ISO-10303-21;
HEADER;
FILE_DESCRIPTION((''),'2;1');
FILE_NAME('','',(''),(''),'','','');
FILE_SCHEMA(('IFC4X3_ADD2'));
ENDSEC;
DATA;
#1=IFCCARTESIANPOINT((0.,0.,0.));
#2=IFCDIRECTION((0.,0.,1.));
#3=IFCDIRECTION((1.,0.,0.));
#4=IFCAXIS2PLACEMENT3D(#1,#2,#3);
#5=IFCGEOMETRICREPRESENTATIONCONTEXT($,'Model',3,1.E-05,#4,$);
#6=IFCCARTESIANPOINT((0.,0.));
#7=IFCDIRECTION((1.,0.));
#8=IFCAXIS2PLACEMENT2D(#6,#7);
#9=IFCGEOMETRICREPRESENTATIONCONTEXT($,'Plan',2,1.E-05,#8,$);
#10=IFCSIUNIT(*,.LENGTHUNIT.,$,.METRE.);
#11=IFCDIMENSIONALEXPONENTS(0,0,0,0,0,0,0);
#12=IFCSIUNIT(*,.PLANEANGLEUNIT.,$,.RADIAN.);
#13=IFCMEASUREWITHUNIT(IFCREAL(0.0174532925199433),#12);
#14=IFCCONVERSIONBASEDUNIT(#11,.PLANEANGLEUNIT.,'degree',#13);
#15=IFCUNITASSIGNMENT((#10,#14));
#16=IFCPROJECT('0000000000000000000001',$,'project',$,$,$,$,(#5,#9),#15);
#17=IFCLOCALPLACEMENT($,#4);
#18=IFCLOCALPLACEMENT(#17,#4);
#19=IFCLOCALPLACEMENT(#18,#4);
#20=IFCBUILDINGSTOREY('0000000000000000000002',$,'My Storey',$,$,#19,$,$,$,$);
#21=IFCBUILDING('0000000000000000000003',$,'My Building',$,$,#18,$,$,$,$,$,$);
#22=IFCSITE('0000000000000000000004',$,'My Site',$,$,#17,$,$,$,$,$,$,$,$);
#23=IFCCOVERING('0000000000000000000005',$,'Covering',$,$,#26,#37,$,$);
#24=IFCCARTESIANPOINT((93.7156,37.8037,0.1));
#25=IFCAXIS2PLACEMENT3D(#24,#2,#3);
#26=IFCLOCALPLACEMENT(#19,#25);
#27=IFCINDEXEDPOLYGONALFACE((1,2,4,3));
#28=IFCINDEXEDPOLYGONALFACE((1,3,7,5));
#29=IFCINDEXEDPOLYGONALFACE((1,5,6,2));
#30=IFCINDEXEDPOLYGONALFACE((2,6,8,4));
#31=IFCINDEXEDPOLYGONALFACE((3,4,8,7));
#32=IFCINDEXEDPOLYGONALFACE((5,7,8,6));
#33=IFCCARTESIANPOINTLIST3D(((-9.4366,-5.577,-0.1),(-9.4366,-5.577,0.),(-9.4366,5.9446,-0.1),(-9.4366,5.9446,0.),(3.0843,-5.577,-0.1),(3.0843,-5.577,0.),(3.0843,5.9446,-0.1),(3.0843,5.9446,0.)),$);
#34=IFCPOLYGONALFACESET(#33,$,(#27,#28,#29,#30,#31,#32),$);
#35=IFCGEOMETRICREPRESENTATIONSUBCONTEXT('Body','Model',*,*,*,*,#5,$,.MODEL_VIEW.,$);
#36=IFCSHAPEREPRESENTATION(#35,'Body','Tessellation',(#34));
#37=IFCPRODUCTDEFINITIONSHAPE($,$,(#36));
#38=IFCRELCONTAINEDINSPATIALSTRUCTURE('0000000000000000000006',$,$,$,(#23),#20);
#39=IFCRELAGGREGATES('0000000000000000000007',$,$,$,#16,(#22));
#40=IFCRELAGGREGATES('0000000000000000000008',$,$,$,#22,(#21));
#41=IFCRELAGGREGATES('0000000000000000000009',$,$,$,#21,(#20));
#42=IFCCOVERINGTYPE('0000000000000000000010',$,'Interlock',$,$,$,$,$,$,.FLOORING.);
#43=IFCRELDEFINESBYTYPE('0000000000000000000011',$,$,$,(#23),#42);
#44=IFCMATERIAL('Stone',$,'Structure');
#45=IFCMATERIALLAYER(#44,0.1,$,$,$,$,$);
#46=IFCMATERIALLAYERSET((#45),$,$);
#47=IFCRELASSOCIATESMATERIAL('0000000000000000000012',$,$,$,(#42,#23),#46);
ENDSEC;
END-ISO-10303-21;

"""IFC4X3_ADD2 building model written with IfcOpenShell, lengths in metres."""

from ifc_helpers import new_model, entity, si_unit, converted_unit, frame, origin_with_axes, origin_2d_with_axis, place, context, subcontext, project, spatial, indexed_curve, outline, extrude, material, layer, layer_set, layer_usage, type_object, element, save


model = new_model("IFC4X3_ADD2")

# Units and contexts
model_context = context("Model", 3, precision=1e-05, world=origin_with_axes())
plan_context = context("Plan", 2, precision=1e-05, world=origin_2d_with_axis())
body_context = subcontext(model_context, "Body", "Model", "MODEL_VIEW")
ifc_project = project(units=[si_unit("LENGTHUNIT", "METRE"), converted_unit("PLANEANGLEUNIT", "degree", entity("IfcReal", 0.0174532925199433), si_unit("PLANEANGLEUNIT", "RADIAN"), dimensions=[0, 0, 0, 0, 0, 0, 0])], contexts=[model_context, plan_context])

# Site, building, storey
site_placement = place(None, origin_with_axes())
site = spatial("IfcSite", under=ifc_project, at=site_placement, Name="My Site")
building_placement = place(site_placement, origin_with_axes())
building = spatial("IfcBuilding", under=site, at=building_placement, Name="My Building")
storey_placement = place(building_placement, origin_with_axes())
storey = spatial("IfcBuildingStorey", under=building, at=storey_placement, Name="My Storey")

# Covering
ifc_material = material(Name="Stone", Category="Structure")
ifc_layer = layer(ifc_material, 0.1)
ifc_layer_set = layer_set([ifc_layer])
ifc_layer_usage = layer_usage(ifc_layer_set, "AXIS3", "POSITIVE", -0.1)
covering_type = type_object("IfcCoveringType", Name="Interlock", PredefinedType="FLOORING", material=ifc_layer_set)
covering_placement = place(storey_placement, frame((93.7156, 37.8037, 0.1), z_axis=(0.0, 0.0, 1.0), x_axis=(1.0, 0.0, 0.0)))
element("IfcCovering", 1, at=covering_placement, inside=storey, type_object=covering_type, material=ifc_layer_usage, Name="Covering", context=body_context, shape_type="SweptSolid", body=[
    extrude(outline(indexed_curve([(-9.4366, -5.577), (3.0843, -5.577), (3.0843, 5.9446), (-9.4366, 5.9446), (-9.4366, -5.577)])), frame((0.0, 0.0, -0.1), z_axis=(0.0, 0.0, 1.0), x_axis=(1.0, 0.0, 0.0)), (0.0, 0.0, 1.0), 0.1),
])

save(model, "model.ifc")
